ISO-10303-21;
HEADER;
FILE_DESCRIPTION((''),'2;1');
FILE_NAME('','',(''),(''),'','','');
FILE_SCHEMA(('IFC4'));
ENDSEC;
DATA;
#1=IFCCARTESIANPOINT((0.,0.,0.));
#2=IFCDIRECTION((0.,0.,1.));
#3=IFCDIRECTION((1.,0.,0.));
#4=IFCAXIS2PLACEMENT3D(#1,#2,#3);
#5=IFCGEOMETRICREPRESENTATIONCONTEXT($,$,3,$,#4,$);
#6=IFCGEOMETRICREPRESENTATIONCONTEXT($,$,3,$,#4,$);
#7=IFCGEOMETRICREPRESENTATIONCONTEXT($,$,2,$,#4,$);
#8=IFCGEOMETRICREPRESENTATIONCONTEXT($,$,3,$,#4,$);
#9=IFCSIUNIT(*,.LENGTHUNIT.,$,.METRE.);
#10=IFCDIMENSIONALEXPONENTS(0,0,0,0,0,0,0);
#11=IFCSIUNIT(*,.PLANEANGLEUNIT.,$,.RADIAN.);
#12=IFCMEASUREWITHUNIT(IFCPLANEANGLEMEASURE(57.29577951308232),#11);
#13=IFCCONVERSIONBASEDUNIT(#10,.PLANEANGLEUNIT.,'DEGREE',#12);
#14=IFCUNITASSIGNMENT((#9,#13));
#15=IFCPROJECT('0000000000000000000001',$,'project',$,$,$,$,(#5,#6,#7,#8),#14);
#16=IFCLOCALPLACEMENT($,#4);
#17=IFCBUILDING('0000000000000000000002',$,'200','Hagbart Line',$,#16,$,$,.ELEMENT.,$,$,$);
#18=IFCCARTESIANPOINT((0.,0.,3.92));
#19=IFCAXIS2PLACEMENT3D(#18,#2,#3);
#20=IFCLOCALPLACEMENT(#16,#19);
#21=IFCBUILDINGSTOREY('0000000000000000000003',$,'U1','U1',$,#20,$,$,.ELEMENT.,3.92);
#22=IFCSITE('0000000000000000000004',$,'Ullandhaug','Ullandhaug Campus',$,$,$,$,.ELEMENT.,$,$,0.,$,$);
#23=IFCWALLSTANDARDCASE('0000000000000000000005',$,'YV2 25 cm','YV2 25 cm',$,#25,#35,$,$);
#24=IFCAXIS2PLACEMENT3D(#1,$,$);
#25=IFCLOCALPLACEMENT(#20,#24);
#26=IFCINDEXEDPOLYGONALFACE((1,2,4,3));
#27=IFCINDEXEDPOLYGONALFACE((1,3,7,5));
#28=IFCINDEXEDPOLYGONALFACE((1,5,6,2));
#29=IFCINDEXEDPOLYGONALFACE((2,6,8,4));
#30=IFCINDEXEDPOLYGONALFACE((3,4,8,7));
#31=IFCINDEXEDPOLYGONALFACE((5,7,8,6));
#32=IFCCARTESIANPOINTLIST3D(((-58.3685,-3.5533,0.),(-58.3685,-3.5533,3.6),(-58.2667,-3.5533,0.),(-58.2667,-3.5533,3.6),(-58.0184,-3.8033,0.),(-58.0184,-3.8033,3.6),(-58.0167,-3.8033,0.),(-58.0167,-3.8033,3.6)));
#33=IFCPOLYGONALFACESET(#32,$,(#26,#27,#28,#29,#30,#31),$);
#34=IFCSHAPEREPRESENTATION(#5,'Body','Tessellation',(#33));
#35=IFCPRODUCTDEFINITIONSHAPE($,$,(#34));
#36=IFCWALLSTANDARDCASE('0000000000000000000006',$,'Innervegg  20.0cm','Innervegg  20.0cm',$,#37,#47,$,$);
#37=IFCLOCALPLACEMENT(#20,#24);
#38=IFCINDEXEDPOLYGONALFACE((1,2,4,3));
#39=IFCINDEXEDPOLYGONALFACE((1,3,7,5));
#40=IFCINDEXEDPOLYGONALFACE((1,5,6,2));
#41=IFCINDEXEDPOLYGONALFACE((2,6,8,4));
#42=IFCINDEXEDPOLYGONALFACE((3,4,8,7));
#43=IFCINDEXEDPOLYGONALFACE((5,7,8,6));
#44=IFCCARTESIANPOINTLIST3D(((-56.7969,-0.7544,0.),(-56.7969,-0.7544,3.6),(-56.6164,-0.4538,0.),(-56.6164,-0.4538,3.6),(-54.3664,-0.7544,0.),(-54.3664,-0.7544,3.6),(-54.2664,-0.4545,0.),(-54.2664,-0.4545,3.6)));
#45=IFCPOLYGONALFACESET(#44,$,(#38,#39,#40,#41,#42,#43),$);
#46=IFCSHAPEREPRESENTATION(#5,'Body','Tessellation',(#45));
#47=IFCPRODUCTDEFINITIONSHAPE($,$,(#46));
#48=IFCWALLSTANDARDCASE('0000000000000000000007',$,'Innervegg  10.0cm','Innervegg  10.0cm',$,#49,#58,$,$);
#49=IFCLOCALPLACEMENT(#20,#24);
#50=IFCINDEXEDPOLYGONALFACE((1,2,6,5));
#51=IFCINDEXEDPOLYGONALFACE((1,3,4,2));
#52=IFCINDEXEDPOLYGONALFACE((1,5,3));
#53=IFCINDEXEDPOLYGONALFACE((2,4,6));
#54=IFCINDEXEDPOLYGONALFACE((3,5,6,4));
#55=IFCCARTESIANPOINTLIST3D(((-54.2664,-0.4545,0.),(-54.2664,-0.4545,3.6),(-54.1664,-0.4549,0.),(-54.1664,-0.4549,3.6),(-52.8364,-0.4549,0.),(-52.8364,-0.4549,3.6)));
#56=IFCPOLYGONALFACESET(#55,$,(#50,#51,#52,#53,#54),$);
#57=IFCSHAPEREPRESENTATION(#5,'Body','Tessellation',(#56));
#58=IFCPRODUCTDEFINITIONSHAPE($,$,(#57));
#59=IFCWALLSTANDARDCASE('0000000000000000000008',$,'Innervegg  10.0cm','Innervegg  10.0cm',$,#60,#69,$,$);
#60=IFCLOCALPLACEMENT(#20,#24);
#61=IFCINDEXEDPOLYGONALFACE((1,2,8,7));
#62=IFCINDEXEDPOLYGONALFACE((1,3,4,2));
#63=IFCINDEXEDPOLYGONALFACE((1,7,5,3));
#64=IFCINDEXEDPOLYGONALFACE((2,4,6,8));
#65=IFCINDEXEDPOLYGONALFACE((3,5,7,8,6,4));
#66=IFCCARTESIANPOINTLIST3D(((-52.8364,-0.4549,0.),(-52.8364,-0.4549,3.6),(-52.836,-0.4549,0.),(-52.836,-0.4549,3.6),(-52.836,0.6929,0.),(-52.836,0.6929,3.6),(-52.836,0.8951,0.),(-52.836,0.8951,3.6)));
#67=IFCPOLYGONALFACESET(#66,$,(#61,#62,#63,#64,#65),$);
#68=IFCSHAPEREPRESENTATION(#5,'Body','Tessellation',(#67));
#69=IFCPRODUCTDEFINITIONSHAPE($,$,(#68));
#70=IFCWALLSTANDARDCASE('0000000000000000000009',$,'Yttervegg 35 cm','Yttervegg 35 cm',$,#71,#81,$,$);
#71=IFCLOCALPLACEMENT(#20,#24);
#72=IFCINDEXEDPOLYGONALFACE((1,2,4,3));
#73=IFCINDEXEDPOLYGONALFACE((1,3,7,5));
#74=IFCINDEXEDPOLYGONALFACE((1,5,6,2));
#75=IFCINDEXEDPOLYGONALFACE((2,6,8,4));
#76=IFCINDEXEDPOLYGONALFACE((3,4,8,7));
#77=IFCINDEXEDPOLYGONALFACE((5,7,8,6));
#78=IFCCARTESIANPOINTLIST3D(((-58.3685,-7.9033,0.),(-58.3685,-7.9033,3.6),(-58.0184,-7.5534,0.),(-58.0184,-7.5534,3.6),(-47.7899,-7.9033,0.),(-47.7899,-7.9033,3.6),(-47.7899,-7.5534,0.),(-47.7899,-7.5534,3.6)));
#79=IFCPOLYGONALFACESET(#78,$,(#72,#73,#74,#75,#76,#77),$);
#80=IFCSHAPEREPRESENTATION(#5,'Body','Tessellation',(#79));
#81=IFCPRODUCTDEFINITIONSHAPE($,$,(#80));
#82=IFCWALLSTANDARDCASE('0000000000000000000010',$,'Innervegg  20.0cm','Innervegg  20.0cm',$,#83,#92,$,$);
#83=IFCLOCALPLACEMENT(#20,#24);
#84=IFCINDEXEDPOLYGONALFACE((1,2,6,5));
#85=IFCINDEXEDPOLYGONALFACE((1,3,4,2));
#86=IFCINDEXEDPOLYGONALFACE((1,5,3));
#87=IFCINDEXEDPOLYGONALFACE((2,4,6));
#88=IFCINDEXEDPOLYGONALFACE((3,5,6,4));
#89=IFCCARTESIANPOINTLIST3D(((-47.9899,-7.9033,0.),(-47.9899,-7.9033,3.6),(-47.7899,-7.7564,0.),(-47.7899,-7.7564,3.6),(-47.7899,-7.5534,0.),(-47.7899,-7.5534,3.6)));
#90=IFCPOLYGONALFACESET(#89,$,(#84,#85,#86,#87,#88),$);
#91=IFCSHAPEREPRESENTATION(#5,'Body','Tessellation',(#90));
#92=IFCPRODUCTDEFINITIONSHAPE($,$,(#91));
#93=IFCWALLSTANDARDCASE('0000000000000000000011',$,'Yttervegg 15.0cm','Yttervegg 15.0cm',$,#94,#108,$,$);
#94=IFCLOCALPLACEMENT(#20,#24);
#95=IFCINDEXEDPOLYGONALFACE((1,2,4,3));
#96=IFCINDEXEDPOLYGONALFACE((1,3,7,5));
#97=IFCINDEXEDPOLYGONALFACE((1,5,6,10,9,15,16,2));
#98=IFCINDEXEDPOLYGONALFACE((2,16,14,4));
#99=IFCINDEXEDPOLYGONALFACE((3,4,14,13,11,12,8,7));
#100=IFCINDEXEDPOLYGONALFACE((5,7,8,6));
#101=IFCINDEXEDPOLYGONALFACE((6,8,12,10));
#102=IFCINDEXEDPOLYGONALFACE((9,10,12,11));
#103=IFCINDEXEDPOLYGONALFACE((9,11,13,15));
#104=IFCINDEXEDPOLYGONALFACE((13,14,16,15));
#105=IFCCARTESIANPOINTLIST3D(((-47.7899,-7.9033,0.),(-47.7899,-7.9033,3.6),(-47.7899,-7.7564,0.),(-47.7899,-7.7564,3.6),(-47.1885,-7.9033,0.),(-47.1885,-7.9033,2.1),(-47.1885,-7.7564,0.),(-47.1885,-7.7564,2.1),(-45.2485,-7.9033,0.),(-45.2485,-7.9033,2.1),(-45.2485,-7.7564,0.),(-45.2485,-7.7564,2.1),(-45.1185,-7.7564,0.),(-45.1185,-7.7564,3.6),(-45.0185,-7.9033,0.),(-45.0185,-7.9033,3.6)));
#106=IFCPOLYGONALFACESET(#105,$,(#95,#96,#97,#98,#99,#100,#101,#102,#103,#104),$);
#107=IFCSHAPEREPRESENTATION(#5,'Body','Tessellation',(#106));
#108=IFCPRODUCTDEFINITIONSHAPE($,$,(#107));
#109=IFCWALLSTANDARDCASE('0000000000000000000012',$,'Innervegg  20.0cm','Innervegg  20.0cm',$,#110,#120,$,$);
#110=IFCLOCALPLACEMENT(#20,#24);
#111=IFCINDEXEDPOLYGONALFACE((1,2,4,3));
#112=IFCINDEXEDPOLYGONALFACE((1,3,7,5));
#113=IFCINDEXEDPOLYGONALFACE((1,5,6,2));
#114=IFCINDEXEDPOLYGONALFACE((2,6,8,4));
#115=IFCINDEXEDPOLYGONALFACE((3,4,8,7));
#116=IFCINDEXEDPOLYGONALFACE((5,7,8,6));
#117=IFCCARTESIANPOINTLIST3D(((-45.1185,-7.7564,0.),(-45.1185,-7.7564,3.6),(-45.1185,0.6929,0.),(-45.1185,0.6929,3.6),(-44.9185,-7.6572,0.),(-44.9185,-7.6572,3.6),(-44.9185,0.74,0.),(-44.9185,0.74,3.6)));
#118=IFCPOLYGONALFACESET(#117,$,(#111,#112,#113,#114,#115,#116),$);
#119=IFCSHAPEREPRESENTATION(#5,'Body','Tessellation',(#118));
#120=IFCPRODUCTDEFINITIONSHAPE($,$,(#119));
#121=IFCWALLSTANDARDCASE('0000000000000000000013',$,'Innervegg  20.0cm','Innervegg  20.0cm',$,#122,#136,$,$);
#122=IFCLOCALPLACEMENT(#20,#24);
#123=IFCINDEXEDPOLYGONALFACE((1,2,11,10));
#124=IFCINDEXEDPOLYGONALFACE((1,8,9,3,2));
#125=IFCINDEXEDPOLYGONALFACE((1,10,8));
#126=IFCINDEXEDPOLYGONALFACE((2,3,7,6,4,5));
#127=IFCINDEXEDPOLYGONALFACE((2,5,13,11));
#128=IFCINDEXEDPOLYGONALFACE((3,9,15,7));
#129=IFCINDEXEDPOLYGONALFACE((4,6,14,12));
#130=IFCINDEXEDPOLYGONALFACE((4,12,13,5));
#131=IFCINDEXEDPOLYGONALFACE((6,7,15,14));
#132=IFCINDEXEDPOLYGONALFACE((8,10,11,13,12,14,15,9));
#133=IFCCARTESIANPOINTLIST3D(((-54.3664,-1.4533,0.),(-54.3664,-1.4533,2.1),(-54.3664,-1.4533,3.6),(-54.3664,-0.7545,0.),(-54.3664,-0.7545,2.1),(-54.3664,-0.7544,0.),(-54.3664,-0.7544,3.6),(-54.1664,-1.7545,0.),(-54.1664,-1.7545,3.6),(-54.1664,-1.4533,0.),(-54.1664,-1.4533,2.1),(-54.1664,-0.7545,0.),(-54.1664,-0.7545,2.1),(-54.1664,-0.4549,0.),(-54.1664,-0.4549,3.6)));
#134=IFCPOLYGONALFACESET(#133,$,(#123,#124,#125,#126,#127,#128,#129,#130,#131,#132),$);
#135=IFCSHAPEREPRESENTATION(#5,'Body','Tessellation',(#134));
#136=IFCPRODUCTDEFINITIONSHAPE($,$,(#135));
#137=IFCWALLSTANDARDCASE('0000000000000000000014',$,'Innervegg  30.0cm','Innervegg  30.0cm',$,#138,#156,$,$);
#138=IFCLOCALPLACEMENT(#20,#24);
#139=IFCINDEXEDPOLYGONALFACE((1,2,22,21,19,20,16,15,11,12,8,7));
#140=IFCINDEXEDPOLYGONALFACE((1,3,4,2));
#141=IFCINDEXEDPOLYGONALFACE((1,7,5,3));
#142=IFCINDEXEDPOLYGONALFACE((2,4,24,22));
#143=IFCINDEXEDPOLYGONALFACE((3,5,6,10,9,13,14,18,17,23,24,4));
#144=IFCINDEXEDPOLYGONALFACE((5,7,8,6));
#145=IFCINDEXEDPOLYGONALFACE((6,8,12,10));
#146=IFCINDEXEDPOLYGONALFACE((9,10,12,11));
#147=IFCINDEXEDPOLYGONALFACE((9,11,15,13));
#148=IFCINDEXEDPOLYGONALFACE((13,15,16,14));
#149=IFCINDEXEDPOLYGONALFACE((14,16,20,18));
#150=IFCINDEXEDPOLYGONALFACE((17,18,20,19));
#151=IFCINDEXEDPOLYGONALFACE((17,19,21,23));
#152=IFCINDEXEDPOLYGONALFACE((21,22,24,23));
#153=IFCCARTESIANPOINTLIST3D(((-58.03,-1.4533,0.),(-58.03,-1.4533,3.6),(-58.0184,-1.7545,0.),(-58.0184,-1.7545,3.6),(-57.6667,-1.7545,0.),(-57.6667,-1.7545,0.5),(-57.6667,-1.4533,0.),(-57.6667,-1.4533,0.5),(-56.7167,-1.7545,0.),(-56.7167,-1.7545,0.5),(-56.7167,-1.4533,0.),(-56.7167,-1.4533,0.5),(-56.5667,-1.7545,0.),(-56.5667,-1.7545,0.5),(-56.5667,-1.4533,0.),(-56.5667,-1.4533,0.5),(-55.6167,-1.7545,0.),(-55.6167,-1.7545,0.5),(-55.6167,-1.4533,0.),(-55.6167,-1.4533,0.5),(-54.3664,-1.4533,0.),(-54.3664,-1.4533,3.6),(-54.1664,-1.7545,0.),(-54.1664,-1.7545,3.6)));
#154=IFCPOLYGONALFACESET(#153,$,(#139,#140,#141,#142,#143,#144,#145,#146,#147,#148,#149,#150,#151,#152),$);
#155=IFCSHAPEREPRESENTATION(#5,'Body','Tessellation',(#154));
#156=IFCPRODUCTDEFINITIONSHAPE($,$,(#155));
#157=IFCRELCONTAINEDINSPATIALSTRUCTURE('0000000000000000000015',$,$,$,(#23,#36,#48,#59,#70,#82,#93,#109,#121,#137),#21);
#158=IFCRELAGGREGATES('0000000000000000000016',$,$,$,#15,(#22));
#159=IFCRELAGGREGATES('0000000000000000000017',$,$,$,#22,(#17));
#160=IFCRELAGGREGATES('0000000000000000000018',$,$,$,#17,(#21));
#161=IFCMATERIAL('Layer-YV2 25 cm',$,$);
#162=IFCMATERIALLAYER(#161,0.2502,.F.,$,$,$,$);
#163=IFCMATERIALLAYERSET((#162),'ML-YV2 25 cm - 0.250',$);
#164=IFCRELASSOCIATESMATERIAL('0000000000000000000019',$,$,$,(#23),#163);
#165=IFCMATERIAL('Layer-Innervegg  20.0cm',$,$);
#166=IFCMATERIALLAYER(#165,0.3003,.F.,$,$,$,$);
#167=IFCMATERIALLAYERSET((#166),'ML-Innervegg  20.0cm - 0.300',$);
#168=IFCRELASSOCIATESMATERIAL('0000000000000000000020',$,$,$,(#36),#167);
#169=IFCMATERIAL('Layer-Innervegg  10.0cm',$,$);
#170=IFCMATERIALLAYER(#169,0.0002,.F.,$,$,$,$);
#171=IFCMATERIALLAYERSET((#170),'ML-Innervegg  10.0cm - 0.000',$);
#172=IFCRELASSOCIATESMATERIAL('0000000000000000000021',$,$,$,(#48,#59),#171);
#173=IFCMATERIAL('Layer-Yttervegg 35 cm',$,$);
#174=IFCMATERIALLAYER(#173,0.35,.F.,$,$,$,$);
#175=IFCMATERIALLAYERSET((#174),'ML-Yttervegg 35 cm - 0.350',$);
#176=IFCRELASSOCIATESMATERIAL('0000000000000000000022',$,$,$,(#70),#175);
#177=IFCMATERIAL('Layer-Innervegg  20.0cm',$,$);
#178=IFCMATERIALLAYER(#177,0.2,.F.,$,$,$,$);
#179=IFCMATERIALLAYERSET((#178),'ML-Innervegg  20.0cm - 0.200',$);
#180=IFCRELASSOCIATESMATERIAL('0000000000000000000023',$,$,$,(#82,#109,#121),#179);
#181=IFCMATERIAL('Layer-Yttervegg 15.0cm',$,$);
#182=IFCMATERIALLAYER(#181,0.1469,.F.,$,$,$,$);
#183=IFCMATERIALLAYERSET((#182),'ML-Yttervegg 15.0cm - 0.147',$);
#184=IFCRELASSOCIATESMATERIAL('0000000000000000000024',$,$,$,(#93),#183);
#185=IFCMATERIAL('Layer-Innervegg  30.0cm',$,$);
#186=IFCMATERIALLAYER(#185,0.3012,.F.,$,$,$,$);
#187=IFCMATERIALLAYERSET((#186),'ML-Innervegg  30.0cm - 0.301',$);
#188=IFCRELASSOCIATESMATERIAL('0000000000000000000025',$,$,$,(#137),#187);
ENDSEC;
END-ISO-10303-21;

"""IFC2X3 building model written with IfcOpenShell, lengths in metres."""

from ifc_helpers import new_model, entity, si_unit, converted_unit, frame, origin_with_axes, place, context, project, spatial, polyline, outline, extrude, material, layer, layer_set, layer_usage, element, save


model = new_model("IFC2X3")

# Units and contexts
context_of_model_1 = context(None, 3, world=origin_with_axes())
context_of_model_2 = context(None, 3, world=origin_with_axes())
context_of_model_3 = context(None, 2, world=origin_with_axes())
context_of_model_4 = context(None, 3, world=origin_with_axes())
ifc_project = project(units=[si_unit("LENGTHUNIT", "METRE"), converted_unit("PLANEANGLEUNIT", "DEGREE", entity("IfcPlaneAngleMeasure", 57.29577951308232), si_unit("PLANEANGLEUNIT", "RADIAN"), dimensions=[0, 0, 0, 0, 0, 0, 0])], contexts=[context_of_model_1, context_of_model_2, context_of_model_3, context_of_model_4])

# Site, building, storey
site = spatial("IfcSite", under=ifc_project, Name="Ullandhaug", Description="Ullandhaug Campus", CompositionType="ELEMENT", RefElevation=0.0)
building_placement = place(None, origin_with_axes())
building = spatial("IfcBuilding", under=site, at=building_placement, Name="200", Description="Hagbart Line", CompositionType="ELEMENT")
storey_placement = place(building_placement, frame((0.0, 0.0, 3.92), z_axis=(0.0, 0.0, 1.0), x_axis=(1.0, 0.0, 0.0)))
storey = spatial("IfcBuildingStorey", under=building, at=storey_placement, Name="U1", Description="U1", CompositionType="ELEMENT", Elevation=3.92)

# Walls
ifc_material_1 = material(Name="Layer-YV2 25 cm")
ifc_layer_1 = layer(ifc_material_1, 0.2502, ventilated=False)
ifc_layer_set_1 = layer_set([ifc_layer_1], Name="ML-YV2 25 cm - 0.250")
ifc_layer_usage_1 = layer_usage(ifc_layer_set_1, "AXIS2", "POSITIVE", 0.0)
wall_1_placement = place(storey_placement, frame((-58.2667, -3.5533, 0.0), z_axis=(0.0, 0.0, 1.0), x_axis=(-1.0, 0.0, 0.0)))
element("IfcWallStandardCase", 1, at=wall_1_placement, inside=storey, material=ifc_layer_usage_1, Name="YV2 25 cm", Description="YV2 25 cm", context=context_of_model_1, shape_type="SweptSolid", body=[
    extrude(outline(polyline([(0.0, 0.0), (0.1018, 0.0), (-0.2483, 0.25), (-0.25, 0.25), (0.0, 0.0)])), frame((0.0, 0.0, 0.0), z_axis=(0.0, 0.0, 1.0), x_axis=(1.0, 0.0, 0.0)), (0.0, 0.0, 1.0), 3.6),
])
ifc_material_2 = material(Name="Layer-Innervegg  20.0cm")
ifc_layer_2 = layer(ifc_material_2, 0.3003, ventilated=False)
ifc_layer_set_2 = layer_set([ifc_layer_2], Name="ML-Innervegg  20.0cm - 0.300")
ifc_layer_usage_2 = layer_usage(ifc_layer_set_2, "AXIS2", "POSITIVE", 0.0)
wall_2_placement = place(storey_placement, frame((-56.7969, -0.7544, 0.0), z_axis=(0.0, 0.0, 1.0), x_axis=(1.0, 0.0, 0.0)))
element("IfcWallStandardCase", 2, at=wall_2_placement, inside=storey, material=ifc_layer_usage_2, Name="Innervegg  20.0cm", Description="Innervegg  20.0cm", context=context_of_model_1, shape_type="SweptSolid", body=[
    extrude(outline(polyline([(0.0, 0.0), (2.4305, 0.0), (2.5306, 0.3), (0.1805, 0.3007), (0.0, 0.0)])), origin_with_axes(), (0.0, 0.0, 1.0), 3.6),
])
ifc_material_3 = material(Name="Layer-Innervegg  10.0cm")
ifc_layer_3 = layer(ifc_material_3, 0.0002, ventilated=False)
ifc_layer_set_3 = layer_set([ifc_layer_3], Name="ML-Innervegg  10.0cm - 0.000")
ifc_layer_usage_3 = layer_usage(ifc_layer_set_3, "AXIS2", "POSITIVE", 0.0)
wall_3_placement = place(storey_placement, frame((-54.1664, -0.4549, 0.0), z_axis=(0.0, 0.0, 1.0), x_axis=(1.0, 0.0, 0.0)))
element("IfcWallStandardCase", 3, at=wall_3_placement, inside=storey, material=ifc_layer_usage_3, Name="Innervegg  10.0cm", Description="Innervegg  10.0cm", context=context_of_model_1, shape_type="SweptSolid", body=[
    extrude(outline(polyline([(0.0, 0.0), (1.3304, 0.0), (1.33, 0.0), (-0.1, 0.0004), (0.0, 0.0)])), frame((0.0, 0.0, 0.0), z_axis=(0.0, 0.0, 1.0), x_axis=(1.0, 0.0, 0.0)), (0.0, 0.0, 1.0), 3.6),
])
wall_4_placement = place(storey_placement, frame((-52.836, -0.4549, 0.0), z_axis=(0.0, 0.0, 1.0), x_axis=(0.0, 1.0, 0.0)))
element("IfcWallStandardCase", 4, at=wall_4_placement, inside=storey, material=ifc_layer_usage_3, Name="Innervegg  10.0cm", Description="Innervegg  10.0cm", context=context_of_model_1, shape_type="SweptSolid", body=[
    extrude(outline(polyline([(0.0, 0.0), (1.1478, 0.0), (1.35, 0.0), (0.0, 0.0003), (0.0, 0.0)])), frame((0.0, 0.0, 0.0), z_axis=(0.0, 0.0, 1.0), x_axis=(1.0, 0.0, 0.0)), (0.0, 0.0, 1.0), 3.6),
])
ifc_material_4 = material(Name="Layer-Yttervegg 35 cm")
ifc_layer_4 = layer(ifc_material_4, 0.35, ventilated=False)
ifc_layer_set_4 = layer_set([ifc_layer_4], Name="ML-Yttervegg 35 cm - 0.350")
ifc_layer_usage_4 = layer_usage(ifc_layer_set_4, "AXIS2", "POSITIVE", 0.0)
wall_5_placement = place(storey_placement, frame((-58.3685, -7.9033, 0.0), z_axis=(0.0, 0.0, 1.0), x_axis=(1.0, 0.0, 0.0)))
element("IfcWallStandardCase", 5, at=wall_5_placement, inside=storey, material=ifc_layer_usage_4, Name="Yttervegg 35 cm", Description="Yttervegg 35 cm", context=context_of_model_1, shape_type="SweptSolid", body=[
    extrude(outline(polyline([(0.0, 0.0), (10.5787, 0.0), (10.5787, 0.3499), (0.3501, 0.3499), (0.0, 0.0)])), origin_with_axes(), (0.0, 0.0, 1.0), 3.6),
])
ifc_material_5 = material(Name="Layer-Innervegg  20.0cm")
ifc_layer_5 = layer(ifc_material_5, 0.2, ventilated=False)
ifc_layer_set_5 = layer_set([ifc_layer_5], Name="ML-Innervegg  20.0cm - 0.200")
ifc_layer_usage_5 = layer_usage(ifc_layer_set_5, "AXIS2", "POSITIVE", 0.0)
wall_6_placement = place(storey_placement, frame((-47.9899, -7.9033, 0.0), z_axis=(0.0, 0.0, 1.0), x_axis=(1.0, 0.0, 0.0)))
element("IfcWallStandardCase", 6, at=wall_6_placement, inside=storey, material=ifc_layer_usage_5, Name="Innervegg  20.0cm", Description="Innervegg  20.0cm", context=context_of_model_1, shape_type="SweptSolid", body=[
    extrude(outline(polyline([(0.0, 0.0), (0.0, 0.0), (0.2482, 0.0), (0.3683, 0.1636), (0.0, 0.0)])), frame((0.0, 0.0, 0.0), z_axis=(0.0, 0.0, 1.0), x_axis=(0.805928, 0.592014, 0.0)), (0.0, 0.0, 1.0), 3.6),
])

# Wall, opening
ifc_material_6 = material(Name="Layer-Yttervegg 15.0cm")
ifc_layer_6 = layer(ifc_material_6, 0.1469, ventilated=False)
ifc_layer_set_6 = layer_set([ifc_layer_6], Name="ML-Yttervegg 15.0cm - 0.147")
ifc_layer_usage_6 = layer_usage(ifc_layer_set_6, "AXIS2", "POSITIVE", 0.0)
wall_7_placement = place(storey_placement, frame((-47.7899, -7.9033, 0.0), z_axis=(0.0, 0.0, 1.0), x_axis=(1.0, 0.0, 0.0)))
wall_7 = element("IfcWallStandardCase", 7, at=wall_7_placement, inside=storey, material=ifc_layer_usage_6, Name="Yttervegg 15.0cm", Description="Yttervegg 15.0cm", context=context_of_model_1, shape_type="SweptSolid", body=[
    extrude(outline(polyline([(0.0, 0.0), (2.7714, 0.0), (2.6714, 0.1469), (0.0, 0.1469), (0.0, 0.0)])), origin_with_axes(), (0.0, 0.0, 1.0), 3.6),
])
opening_1_placement = place(wall_7_placement, frame((0.6013, 0.1469, 0.0), z_axis=(0.0, 0.0, 1.0), x_axis=(1.0, 0.0, 0.0)))
element("IfcOpeningElement", 8, at=opening_1_placement, cuts=wall_7, context=context_of_model_1, shape_type="SweptSolid", body=[
    extrude(outline(polyline([(0.0, 0.0), (2.1, 0.0), (2.1, 1.94), (0.0, 1.94), (0.0, 0.0)])), frame((0.0, 0.0, 0.0), z_axis=(0.0, 1.0, 0.0), x_axis=(0.0, 0.0, 1.0)), (0.0, 0.0, -1.0), 0.1469),
])

# Wall
wall_8_placement = place(storey_placement, frame((-44.9185, -7.6572, 0.0), z_axis=(0.0, 0.0, 1.0), x_axis=(0.0, 1.0, 0.0)))
element("IfcWallStandardCase", 9, at=wall_8_placement, inside=storey, material=ifc_layer_usage_5, Name="Innervegg  20.0cm", Description="Innervegg  20.0cm", context=context_of_model_1, shape_type="SweptSolid", body=[
    extrude(outline(polyline([(0.0, 0.0), (8.3972, 0.0), (8.3501, 0.2), (-0.0992, 0.2), (0.0, 0.0)])), frame((0.0, 0.0, 0.0), z_axis=(0.0, 0.0, 1.0), x_axis=(1.0, 0.0, 0.0)), (0.0, 0.0, 1.0), 3.6),
])

# Wall, opening
wall_9_placement = place(storey_placement, frame((-54.3664, -0.7544, 0.0), z_axis=(0.0, 0.0, 1.0), x_axis=(0.0, -1.0, 0.0)))
wall_9 = element("IfcWallStandardCase", 10, at=wall_9_placement, inside=storey, material=ifc_layer_usage_5, Name="Innervegg  20.0cm", Description="Innervegg  20.0cm", context=context_of_model_1, shape_type="SweptSolid", body=[
    extrude(outline(polyline([(0.0, 0.0), (0.6988, 0.0), (1.0001, 0.2), (-0.2996, 0.2), (0.0, 0.0)])), frame((0.0, 0.0, 0.0), z_axis=(0.0, 0.0, 1.0), x_axis=(1.0, 0.0, 0.0)), (0.0, 0.0, 1.0), 3.6),
])
opening_2_placement = place(wall_9_placement, frame((0.0001, 0.2, 0.0), z_axis=(0.0, 0.0, 1.0), x_axis=(1.0, 0.0, 0.0)))
element("IfcOpeningElement", 11, at=opening_2_placement, cuts=wall_9, context=context_of_model_1, shape_type="SweptSolid", body=[
    extrude(outline(polyline([(0.0, 0.0), (2.1, 0.0), (2.1, 0.6988), (0.0, 0.6988), (0.0, 0.0)])), frame((0.0, 0.0, 0.0), z_axis=(0.0, 1.0, 0.0), x_axis=(0.0, 0.0, 1.0)), (0.0, 0.0, -1.0), 0.2),
])

# Wall, openings
ifc_material_7 = material(Name="Layer-Innervegg  30.0cm")
ifc_layer_7 = layer(ifc_material_7, 0.3012, ventilated=False)
ifc_layer_set_7 = layer_set([ifc_layer_7], Name="ML-Innervegg  30.0cm - 0.301")
ifc_layer_usage_7 = layer_usage(ifc_layer_set_7, "AXIS2", "POSITIVE", 0.0)
wall_10_placement = place(storey_placement, frame((-54.3664, -1.4533, 0.0), z_axis=(0.0, 0.0, 1.0), x_axis=(-1.0, 0.0, 0.0)))
wall_10 = element("IfcWallStandardCase", 12, at=wall_10_placement, inside=storey, material=ifc_layer_usage_7, Name="Innervegg  30.0cm", Description="Innervegg  30.0cm", context=context_of_model_1, shape_type="SweptSolid", body=[
    extrude(outline(polyline([(0.0, 0.0), (3.6636, 0.0), (3.652, 0.3012), (-0.2, 0.3012), (0.0, 0.0)])), frame((0.0, 0.0, 0.0), z_axis=(0.0, 0.0, 1.0), x_axis=(1.0, 0.0, 0.0)), (0.0, 0.0, 1.0), 3.6),
])
opening_3_placement = place(wall_10_placement, frame((2.3503, 0.3012, 0.0), z_axis=(0.0, 0.0, 1.0), x_axis=(1.0, 0.0, 0.0)))
element("IfcOpeningElement", 13, at=opening_3_placement, cuts=wall_10, context=context_of_model_1, shape_type="SweptSolid", body=[
    extrude(outline(polyline([(0.0, 0.0), (0.5, 0.0), (0.5, 0.95), (0.0, 0.95), (0.0, 0.0)])), frame((0.0, 0.0, 0.0), z_axis=(0.0, 1.0, 0.0), x_axis=(0.0, 0.0, 1.0)), (0.0, 0.0, -1.0), 0.3012),
])
opening_4_placement = place(wall_10_placement, frame((1.2503, 0.3012, 0.0), z_axis=(0.0, 0.0, 1.0), x_axis=(1.0, 0.0, 0.0)))
element("IfcOpeningElement", 14, at=opening_4_placement, cuts=wall_10, context=context_of_model_1, shape_type="SweptSolid", body=[
    extrude(outline(polyline([(0.0, 0.0), (0.5, 0.0), (0.5, 0.95), (0.0, 0.95), (0.0, 0.0)])), frame((0.0, 0.0, 0.0), z_axis=(0.0, 1.0, 0.0), x_axis=(0.0, 0.0, 1.0)), (0.0, 0.0, -1.0), 0.3012),
])

save(model, "model.ifc")
